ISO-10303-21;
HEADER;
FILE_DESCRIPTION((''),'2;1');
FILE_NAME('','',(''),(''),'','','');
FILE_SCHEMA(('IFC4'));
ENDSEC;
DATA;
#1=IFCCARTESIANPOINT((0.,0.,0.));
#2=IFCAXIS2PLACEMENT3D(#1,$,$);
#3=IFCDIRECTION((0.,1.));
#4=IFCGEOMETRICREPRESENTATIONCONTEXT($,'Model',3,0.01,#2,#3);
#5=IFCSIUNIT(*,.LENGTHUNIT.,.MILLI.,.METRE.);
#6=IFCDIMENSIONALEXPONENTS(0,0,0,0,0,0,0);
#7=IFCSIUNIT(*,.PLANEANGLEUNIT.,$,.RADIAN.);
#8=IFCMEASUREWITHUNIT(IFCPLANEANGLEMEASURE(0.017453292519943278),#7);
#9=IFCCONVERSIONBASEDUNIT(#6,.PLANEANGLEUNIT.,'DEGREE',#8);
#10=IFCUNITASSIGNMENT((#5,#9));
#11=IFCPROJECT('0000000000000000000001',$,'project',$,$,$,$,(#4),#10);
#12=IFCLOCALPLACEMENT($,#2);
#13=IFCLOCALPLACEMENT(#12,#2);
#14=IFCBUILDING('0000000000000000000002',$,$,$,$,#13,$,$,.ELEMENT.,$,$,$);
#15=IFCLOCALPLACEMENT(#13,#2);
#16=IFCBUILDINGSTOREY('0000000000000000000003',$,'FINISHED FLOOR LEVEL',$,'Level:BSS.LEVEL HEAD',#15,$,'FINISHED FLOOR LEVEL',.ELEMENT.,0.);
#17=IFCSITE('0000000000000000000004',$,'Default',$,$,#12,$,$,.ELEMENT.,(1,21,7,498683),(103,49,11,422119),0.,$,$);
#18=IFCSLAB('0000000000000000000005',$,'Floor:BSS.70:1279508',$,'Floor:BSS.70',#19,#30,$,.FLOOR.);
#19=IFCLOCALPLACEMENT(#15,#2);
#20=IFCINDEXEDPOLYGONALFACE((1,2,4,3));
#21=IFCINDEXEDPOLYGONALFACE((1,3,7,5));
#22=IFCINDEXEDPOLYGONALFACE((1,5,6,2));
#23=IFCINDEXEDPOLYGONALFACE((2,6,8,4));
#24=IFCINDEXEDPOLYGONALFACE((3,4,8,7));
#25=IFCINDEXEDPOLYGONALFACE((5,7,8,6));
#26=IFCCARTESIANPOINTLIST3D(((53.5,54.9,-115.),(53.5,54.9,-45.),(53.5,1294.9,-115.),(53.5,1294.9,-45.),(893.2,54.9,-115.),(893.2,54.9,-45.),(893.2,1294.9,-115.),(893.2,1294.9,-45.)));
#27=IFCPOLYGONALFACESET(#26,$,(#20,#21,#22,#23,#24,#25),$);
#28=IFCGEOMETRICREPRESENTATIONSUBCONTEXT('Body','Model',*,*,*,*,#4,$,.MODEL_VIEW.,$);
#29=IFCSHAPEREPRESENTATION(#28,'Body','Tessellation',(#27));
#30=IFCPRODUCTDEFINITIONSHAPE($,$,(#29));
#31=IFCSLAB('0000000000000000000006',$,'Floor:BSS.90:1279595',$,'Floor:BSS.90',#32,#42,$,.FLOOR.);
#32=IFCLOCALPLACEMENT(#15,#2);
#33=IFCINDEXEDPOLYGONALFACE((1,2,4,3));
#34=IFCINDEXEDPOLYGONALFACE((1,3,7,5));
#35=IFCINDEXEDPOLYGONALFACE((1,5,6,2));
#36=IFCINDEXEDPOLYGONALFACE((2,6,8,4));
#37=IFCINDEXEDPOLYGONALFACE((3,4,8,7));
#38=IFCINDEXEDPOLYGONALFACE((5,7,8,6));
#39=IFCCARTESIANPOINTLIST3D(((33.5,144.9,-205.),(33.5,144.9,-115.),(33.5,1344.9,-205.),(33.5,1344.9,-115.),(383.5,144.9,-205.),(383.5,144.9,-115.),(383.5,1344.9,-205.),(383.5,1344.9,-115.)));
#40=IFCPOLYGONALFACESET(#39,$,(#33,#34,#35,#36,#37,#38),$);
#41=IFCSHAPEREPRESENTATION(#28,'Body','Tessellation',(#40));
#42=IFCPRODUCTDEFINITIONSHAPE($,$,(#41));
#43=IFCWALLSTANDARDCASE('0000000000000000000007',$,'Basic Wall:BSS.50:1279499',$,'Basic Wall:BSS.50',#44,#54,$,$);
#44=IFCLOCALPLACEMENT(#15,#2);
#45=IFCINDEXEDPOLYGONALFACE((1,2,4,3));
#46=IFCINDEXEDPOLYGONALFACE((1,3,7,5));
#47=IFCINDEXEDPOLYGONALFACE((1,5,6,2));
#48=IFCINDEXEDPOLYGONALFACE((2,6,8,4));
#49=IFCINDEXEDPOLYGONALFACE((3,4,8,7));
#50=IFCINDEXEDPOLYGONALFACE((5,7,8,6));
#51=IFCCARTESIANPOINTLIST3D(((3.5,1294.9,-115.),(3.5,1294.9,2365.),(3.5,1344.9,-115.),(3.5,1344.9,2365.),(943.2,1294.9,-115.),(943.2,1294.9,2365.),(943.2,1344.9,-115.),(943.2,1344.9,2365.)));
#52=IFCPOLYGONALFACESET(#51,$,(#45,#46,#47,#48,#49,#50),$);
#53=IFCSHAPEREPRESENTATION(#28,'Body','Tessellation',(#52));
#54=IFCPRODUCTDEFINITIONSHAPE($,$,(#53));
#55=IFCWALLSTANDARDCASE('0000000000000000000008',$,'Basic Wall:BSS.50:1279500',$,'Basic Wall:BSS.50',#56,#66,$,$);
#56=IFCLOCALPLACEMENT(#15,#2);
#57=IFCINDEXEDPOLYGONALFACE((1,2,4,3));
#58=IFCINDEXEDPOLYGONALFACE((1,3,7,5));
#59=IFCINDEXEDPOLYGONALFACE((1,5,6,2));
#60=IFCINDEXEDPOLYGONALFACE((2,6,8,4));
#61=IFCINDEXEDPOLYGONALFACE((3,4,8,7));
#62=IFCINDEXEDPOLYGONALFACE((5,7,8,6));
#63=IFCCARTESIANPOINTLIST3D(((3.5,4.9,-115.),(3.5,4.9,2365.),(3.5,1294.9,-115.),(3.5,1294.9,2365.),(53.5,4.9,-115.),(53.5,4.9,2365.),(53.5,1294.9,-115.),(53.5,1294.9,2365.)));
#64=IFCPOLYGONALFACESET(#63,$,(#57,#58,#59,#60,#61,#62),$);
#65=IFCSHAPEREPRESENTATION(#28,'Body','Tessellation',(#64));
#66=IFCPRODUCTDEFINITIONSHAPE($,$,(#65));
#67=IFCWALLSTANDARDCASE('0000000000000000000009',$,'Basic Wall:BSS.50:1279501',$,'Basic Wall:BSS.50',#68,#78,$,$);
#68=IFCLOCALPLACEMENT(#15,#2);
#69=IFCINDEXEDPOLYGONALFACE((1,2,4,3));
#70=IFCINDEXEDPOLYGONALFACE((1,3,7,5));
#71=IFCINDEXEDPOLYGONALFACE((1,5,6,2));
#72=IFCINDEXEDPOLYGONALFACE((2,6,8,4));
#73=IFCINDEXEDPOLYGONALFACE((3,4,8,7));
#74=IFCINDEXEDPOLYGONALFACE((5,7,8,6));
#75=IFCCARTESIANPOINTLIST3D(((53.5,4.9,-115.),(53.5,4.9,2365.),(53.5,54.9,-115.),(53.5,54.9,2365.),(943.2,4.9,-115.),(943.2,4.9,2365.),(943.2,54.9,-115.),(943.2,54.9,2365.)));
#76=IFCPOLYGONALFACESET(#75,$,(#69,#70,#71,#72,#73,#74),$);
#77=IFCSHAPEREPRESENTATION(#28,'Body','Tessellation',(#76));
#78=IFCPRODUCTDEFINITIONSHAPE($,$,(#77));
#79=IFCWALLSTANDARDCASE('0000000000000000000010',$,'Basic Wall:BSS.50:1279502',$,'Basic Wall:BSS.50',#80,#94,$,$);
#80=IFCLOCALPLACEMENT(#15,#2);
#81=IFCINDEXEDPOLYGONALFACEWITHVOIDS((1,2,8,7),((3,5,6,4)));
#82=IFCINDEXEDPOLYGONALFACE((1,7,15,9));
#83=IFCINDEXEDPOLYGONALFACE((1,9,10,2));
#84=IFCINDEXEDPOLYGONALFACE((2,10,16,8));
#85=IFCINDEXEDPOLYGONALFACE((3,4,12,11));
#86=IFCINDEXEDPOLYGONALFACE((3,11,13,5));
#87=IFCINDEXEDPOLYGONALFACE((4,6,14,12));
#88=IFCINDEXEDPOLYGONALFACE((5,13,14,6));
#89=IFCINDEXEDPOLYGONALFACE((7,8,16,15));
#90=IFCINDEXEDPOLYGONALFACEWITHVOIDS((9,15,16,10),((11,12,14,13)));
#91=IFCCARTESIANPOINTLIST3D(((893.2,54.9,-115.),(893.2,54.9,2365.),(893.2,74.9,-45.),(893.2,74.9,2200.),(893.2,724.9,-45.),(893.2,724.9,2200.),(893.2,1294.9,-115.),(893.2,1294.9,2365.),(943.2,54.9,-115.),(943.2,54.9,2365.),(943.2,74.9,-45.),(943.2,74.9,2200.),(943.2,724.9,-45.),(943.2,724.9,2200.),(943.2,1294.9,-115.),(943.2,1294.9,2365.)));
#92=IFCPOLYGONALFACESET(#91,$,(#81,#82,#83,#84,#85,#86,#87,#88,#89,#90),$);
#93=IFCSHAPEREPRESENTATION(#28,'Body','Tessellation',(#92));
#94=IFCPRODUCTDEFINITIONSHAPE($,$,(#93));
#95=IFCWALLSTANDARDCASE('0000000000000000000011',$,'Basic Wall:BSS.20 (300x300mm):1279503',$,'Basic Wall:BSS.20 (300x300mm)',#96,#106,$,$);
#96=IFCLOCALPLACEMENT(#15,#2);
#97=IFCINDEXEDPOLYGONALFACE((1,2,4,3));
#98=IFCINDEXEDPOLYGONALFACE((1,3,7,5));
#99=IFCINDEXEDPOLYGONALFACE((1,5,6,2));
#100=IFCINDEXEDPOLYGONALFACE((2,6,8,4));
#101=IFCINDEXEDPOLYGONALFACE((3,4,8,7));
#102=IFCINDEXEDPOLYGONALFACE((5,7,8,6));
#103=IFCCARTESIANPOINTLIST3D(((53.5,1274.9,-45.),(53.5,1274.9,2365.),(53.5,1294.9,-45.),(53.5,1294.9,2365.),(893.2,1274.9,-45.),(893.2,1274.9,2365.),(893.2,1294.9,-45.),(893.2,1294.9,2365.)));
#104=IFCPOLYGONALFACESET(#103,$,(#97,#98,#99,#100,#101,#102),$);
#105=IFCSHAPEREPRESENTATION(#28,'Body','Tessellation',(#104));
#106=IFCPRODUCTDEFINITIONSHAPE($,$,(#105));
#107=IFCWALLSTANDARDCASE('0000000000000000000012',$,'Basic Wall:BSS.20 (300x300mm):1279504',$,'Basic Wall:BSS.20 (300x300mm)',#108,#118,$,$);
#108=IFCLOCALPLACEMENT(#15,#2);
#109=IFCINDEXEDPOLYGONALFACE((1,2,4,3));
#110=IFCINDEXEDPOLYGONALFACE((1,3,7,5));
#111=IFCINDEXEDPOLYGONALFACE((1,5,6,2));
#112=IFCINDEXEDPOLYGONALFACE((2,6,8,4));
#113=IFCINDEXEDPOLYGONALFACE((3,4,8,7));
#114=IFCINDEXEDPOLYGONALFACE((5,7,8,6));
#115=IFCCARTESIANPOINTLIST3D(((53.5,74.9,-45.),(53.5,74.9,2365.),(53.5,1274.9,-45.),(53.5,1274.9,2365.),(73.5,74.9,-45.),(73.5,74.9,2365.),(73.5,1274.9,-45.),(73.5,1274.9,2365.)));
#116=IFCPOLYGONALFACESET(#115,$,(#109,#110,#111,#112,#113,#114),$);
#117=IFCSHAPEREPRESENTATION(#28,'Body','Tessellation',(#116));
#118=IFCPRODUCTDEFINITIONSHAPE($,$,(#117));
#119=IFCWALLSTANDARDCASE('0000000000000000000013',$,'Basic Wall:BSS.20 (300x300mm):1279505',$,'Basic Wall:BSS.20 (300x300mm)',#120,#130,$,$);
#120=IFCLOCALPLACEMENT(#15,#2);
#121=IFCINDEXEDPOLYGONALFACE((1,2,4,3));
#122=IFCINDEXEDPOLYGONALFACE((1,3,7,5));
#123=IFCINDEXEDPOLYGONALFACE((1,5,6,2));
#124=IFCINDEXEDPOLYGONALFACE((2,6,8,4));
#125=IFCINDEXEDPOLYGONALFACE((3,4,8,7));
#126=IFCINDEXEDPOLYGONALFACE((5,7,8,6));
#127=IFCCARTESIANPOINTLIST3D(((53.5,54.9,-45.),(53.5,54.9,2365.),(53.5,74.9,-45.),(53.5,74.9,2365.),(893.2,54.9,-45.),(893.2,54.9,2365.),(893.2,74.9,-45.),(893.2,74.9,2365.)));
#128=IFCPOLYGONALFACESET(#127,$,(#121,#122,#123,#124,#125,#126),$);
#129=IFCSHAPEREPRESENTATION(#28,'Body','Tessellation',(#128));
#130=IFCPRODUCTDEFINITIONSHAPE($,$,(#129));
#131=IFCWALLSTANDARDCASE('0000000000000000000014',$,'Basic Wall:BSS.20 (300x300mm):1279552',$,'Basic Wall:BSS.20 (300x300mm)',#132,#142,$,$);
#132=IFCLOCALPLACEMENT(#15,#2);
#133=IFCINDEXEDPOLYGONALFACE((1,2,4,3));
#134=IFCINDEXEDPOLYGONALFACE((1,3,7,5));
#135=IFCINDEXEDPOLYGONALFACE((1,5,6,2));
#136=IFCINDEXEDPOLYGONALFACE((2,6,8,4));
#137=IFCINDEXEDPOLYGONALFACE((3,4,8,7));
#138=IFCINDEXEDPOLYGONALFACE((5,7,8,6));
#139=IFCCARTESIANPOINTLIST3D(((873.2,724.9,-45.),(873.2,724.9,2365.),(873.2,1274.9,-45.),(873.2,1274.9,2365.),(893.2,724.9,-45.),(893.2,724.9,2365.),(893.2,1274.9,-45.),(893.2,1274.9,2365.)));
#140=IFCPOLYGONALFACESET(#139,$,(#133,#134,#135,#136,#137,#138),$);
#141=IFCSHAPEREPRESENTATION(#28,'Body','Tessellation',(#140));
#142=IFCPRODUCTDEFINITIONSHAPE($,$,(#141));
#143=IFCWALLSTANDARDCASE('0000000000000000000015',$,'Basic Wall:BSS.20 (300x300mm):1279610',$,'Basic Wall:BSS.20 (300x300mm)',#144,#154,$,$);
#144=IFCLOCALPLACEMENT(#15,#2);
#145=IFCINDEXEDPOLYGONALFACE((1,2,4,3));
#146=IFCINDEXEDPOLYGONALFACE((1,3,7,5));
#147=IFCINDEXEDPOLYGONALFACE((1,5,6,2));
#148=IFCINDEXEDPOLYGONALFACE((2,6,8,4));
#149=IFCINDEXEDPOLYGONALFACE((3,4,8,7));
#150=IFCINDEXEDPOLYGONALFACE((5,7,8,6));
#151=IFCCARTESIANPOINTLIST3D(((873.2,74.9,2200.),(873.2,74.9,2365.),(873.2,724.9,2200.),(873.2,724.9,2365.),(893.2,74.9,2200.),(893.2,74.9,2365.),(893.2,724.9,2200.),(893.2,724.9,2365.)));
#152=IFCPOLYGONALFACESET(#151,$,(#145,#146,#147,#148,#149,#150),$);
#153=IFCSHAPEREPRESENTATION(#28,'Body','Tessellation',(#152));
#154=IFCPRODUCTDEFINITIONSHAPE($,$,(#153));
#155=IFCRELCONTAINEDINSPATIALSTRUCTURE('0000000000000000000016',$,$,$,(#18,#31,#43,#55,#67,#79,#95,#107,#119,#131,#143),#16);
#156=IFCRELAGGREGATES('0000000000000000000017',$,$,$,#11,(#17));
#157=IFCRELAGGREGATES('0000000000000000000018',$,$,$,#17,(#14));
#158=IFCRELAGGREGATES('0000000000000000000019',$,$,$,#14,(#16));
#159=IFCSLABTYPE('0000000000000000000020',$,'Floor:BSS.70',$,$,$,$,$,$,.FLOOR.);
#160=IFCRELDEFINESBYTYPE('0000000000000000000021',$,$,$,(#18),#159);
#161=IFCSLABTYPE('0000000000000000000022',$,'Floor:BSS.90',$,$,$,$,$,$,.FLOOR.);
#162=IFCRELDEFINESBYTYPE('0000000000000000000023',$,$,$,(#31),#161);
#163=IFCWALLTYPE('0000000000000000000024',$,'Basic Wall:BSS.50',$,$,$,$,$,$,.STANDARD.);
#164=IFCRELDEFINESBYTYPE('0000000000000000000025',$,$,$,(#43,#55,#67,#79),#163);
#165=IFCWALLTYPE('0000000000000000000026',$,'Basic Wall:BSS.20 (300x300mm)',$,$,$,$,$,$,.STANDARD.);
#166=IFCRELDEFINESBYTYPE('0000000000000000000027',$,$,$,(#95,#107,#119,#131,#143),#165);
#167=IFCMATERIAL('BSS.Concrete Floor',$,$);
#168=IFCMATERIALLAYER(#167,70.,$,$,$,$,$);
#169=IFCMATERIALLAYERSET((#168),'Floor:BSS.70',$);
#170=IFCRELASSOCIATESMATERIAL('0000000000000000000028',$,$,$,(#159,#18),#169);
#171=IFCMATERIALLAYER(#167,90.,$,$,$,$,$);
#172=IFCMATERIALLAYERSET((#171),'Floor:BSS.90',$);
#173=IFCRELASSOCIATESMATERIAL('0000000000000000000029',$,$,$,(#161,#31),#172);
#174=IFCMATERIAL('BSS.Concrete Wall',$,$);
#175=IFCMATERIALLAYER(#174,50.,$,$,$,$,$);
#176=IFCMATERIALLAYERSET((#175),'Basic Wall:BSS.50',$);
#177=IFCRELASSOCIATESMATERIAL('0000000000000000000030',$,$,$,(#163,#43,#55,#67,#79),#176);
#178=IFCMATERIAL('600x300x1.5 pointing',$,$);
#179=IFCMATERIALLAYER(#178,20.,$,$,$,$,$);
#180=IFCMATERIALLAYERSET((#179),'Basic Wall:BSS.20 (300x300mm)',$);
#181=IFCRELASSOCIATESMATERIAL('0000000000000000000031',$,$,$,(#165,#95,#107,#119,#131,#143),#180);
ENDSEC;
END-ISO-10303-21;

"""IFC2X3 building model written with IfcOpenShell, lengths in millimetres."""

from ifc_helpers import new_model, entity, si_unit, converted_unit, direction, frame, frame_2d, origin, place, context, subcontext, project, spatial, polyline, rectangle, extrude, clip, halfspace, bounded_halfspace, material, layer, layer_set, layer_usage, type_object, element, save


model = new_model("IFC2X3")

# Units and contexts
model_context = context("Model", 3, precision=0.01, world=origin(), true_north=direction((0.0, 1.0)))
body_context = subcontext(model_context, "Body", "Model", "MODEL_VIEW")
ifc_project = project(units=[si_unit("LENGTHUNIT", "METRE", prefix="MILLI"), converted_unit("PLANEANGLEUNIT", "DEGREE", entity("IfcPlaneAngleMeasure", 0.017453292519943278), si_unit("PLANEANGLEUNIT", "RADIAN"), dimensions=[0, 0, 0, 0, 0, 0, 0])], contexts=[model_context])

# Site, building, storey
site_placement = place(None, origin())
site = spatial("IfcSite", under=ifc_project, at=site_placement, Name="Default", CompositionType="ELEMENT", RefLatitude=(1, 21, 7, 498683), RefLongitude=(103, 49, 11, 422119), RefElevation=0.0)
building_placement = place(site_placement, origin())
building = spatial("IfcBuilding", under=site, at=building_placement, CompositionType="ELEMENT")
storey_placement = place(building_placement, origin())
storey = spatial("IfcBuildingStorey", under=building, at=storey_placement, Name="FINISHED FLOOR LEVEL", ObjectType="Level:BSS.LEVEL HEAD", LongName="FINISHED FLOOR LEVEL", CompositionType="ELEMENT", Elevation=0.0)

# Slabs
ifc_material_1 = material(Name="BSS.Concrete Floor")
ifc_layer_1 = layer(ifc_material_1, 70.0)
ifc_layer_set_1 = layer_set([ifc_layer_1], Name="Floor:BSS.70")
ifc_layer_usage_1 = layer_usage(ifc_layer_set_1, "AXIS3", "POSITIVE", 0.0)
slab_type_1 = type_object("IfcSlabType", Name="Floor:BSS.70", PredefinedType="FLOOR", material=ifc_layer_set_1)
slab_1_placement = place(storey_placement, origin())
element("IfcSlab", 1, at=slab_1_placement, inside=storey, type_object=slab_type_1, material=ifc_layer_usage_1, Name="Floor:BSS.70:1279508", ObjectType="Floor:BSS.70", PredefinedType="FLOOR", context=body_context, shape_type="SweptSolid", body=[
    extrude(rectangle(XDim=1240.0, YDim=839.7, at=frame_2d((0.0, 0.0), x_axis=(1.0, 0.0))), frame((473.3, 674.9, -45.0), z_axis=(0.0, 0.0, -1.0), x_axis=(0.0, 1.0, 0.0)), (0.0, 0.0, 1.0), 70.0),
])
ifc_material_2 = material(Name="600x300x1.5 pointing")
ifc_layer_2 = layer(ifc_material_1, 90.0)
ifc_layer_set_2 = layer_set([ifc_layer_2], Name="Floor:BSS.90")
ifc_layer_usage_2 = layer_usage(ifc_layer_set_2, "AXIS3", "POSITIVE", 0.0)
slab_type_2 = type_object("IfcSlabType", Name="Floor:BSS.90", PredefinedType="FLOOR", material=ifc_layer_set_2)
slab_2_placement = place(storey_placement, origin())
element("IfcSlab", 2, at=slab_2_placement, inside=storey, type_object=slab_type_2, material=ifc_layer_usage_2, Name="Floor:BSS.90:1279595", ObjectType="Floor:BSS.90", PredefinedType="FLOOR", context=body_context, shape_type="SweptSolid", body=[
    extrude(rectangle(XDim=1200.0, YDim=350.0, at=frame_2d((0.0, 0.0), x_axis=(1.0, 0.0))), frame((208.5, 744.9, -115.0), z_axis=(0.0, 0.0, -1.0), x_axis=(0.0, 1.0, 0.0)), (0.0, 0.0, 1.0), 90.0),
])

# Walls
ifc_material_3 = material(Name="BSS.Concrete Wall")
ifc_layer_3 = layer(ifc_material_3, 50.0)
ifc_layer_set_3 = layer_set([ifc_layer_3], Name="Basic Wall:BSS.50")
ifc_layer_usage_3 = layer_usage(ifc_layer_set_3, "AXIS2", "POSITIVE", -25.0)
wall_type_1 = type_object("IfcWallType", Name="Basic Wall:BSS.50", PredefinedType="STANDARD", material=ifc_layer_set_3)
wall_1_placement = place(storey_placement, frame((943.2, 1319.9, -115.0), z_axis=(0.0, 0.0, 1.0), x_axis=(-1.0, 0.0, 0.0)))
element("IfcWallStandardCase", 3, at=wall_1_placement, inside=storey, type_object=wall_type_1, material=ifc_layer_usage_3, Name="Basic Wall:BSS.50:1279499", ObjectType="Basic Wall:BSS.50", context=body_context, shape_type="Clipping", body=[
    clip(extrude(rectangle(XDim=939.7, YDim=50.0, at=frame_2d((469.9, 0.0), x_axis=(-1.0, 0.0))), origin(), (0.0, 0.0, 1.0), 2480.0), bounded_halfspace(frame((0.0, -25.0, 2480.0), z_axis=(0.0, 0.0, -1.0), x_axis=(0.0, 1.0, 0.0)), True, frame((0.0, -25.0, 2480.0)), polyline([(0.0, 0.0), (939.7, 0.0), (939.7, 50.0), (889.7, 50.0), (50.0, 50.0), (0.0, 50.0), (0.0, 0.0)]))),
])
ifc_layer_usage_4 = layer_usage(ifc_layer_set_3, "AXIS2", "NEGATIVE", 25.0)
wall_2_placement = place(storey_placement, frame((28.5, 1294.9, -115.0), z_axis=(0.0, 0.0, 1.0), x_axis=(0.0, -1.0, 0.0)))
element("IfcWallStandardCase", 4, at=wall_2_placement, inside=storey, type_object=wall_type_1, material=ifc_layer_usage_4, Name="Basic Wall:BSS.50:1279500", ObjectType="Basic Wall:BSS.50", context=body_context, shape_type="Clipping", body=[
    clip(extrude(rectangle(XDim=1290.0, YDim=50.0, at=frame_2d((645.0, 0.0), x_axis=(-1.0, 0.0))), origin(), (0.0, 0.0, 1.0), 2480.0), bounded_halfspace(frame((0.0, -25.0, 2480.0), z_axis=(0.0, 0.0, -1.0), x_axis=(1.0, 0.0, 0.0)), True, frame((0.0, -25.0, 2480.0)), polyline([(0.0, 0.0), (1290.0, 0.0), (1290.0, 50.0), (1240.0, 50.0), (0.0, 50.0), (0.0, 0.0)]))),
])
ifc_layer_usage_5 = layer_usage(ifc_layer_set_3, "AXIS2", "NEGATIVE", 25.0)
wall_3_placement = place(storey_placement, frame((53.5, 29.9, -115.0)))
element("IfcWallStandardCase", 5, at=wall_3_placement, inside=storey, type_object=wall_type_1, material=ifc_layer_usage_5, Name="Basic Wall:BSS.50:1279501", ObjectType="Basic Wall:BSS.50", context=body_context, shape_type="Clipping", body=[
    clip(extrude(rectangle(XDim=889.7, YDim=50.0, at=frame_2d((444.9, 0.0), x_axis=(-1.0, 0.0))), origin(), (0.0, 0.0, 1.0), 2480.0), bounded_halfspace(frame((0.0, -25.0, 2480.0), z_axis=(0.0, 0.0, -1.0), x_axis=(0.0, -1.0, 0.0)), True, frame((0.0, -25.0, 2480.0)), polyline([(0.0, 0.0), (889.7, 0.0), (889.7, 50.0), (839.7, 50.0), (0.0, 50.0), (0.0, 0.0)]))),
])

# Wall, opening
ifc_layer_usage_6 = layer_usage(ifc_layer_set_3, "AXIS2", "POSITIVE", -25.0)
wall_4_placement = place(storey_placement, frame((918.2, 54.9, -115.0), z_axis=(0.0, 0.0, 1.0), x_axis=(0.0, 1.0, 0.0)))
wall_4 = element("IfcWallStandardCase", 6, at=wall_4_placement, inside=storey, type_object=wall_type_1, material=ifc_layer_usage_6, Name="Basic Wall:BSS.50:1279502", ObjectType="Basic Wall:BSS.50", context=body_context, shape_type="Clipping", body=[
    clip(extrude(rectangle(XDim=1240.0, YDim=50.0, at=frame_2d((620.0, 0.0), x_axis=(-1.0, 0.0))), origin(), (0.0, 0.0, 1.0), 2480.0), bounded_halfspace(frame((0.0, -25.0, 2480.0), z_axis=(0.0, 0.0, -1.0), x_axis=(-1.0, 0.0, 0.0)), True, frame((0.0, -25.0, 2480.0)), polyline([(0.0, 0.0), (1240.0, 0.0), (1240.0, 50.0), (1220.0, 50.0), (0.0, 50.0), (0.0, 0.0)]))),
])
opening_placement = place(wall_4_placement, frame((-54.9, 918.2, 115.0), z_axis=(0.0, 0.0, 1.0), x_axis=(0.0, -1.0, 0.0)))
element("IfcOpeningElement", 7, at=opening_placement, cuts=wall_4, ObjectType="Opening", context=body_context, shape_type="SweptSolid", body=[
    extrude(rectangle(XDim=2245.0, YDim=650.0, at=frame_2d((0.0, 0.0), x_axis=(0.0, 1.0))), frame((2417.2, 399.9, 1077.5), z_axis=(-1.0, 0.0, 0.0), x_axis=(0.0, 1.0, 0.0)), (0.0, 0.0, 1.0), 3048.0),
])

# Walls
ifc_layer_4 = layer(ifc_material_2, 20.0)
ifc_layer_set_4 = layer_set([ifc_layer_4], Name="Basic Wall:BSS.20 (300x300mm)")
ifc_layer_usage_7 = layer_usage(ifc_layer_set_4, "AXIS2", "POSITIVE", -10.0)
wall_type_2 = type_object("IfcWallType", Name="Basic Wall:BSS.20 (300x300mm)", PredefinedType="STANDARD", material=ifc_layer_set_4)
wall_5_placement = place(storey_placement, frame((893.2, 1284.9, -45.0), z_axis=(0.0, 0.0, 1.0), x_axis=(-1.0, 0.0, 0.0)))
element("IfcWallStandardCase", 8, at=wall_5_placement, inside=storey, type_object=wall_type_2, material=ifc_layer_usage_7, Name="Basic Wall:BSS.20 (300x300mm):1279503", ObjectType="Basic Wall:BSS.20 (300x300mm)", context=body_context, shape_type="SweptSolid", body=[
    extrude(rectangle(XDim=839.7, YDim=20.0, at=frame_2d((419.9, 0.0), x_axis=(-1.0, 0.0))), origin(), (0.0, 0.0, 1.0), 2410.0),
])
ifc_layer_usage_8 = layer_usage(ifc_layer_set_4, "AXIS2", "NEGATIVE", 10.0)
wall_6_placement = place(storey_placement, frame((63.5, 74.9, -45.0), z_axis=(0.0, 0.0, 1.0), x_axis=(0.0, 1.0, 0.0)))
element("IfcWallStandardCase", 9, at=wall_6_placement, inside=storey, type_object=wall_type_2, material=ifc_layer_usage_8, Name="Basic Wall:BSS.20 (300x300mm):1279504", ObjectType="Basic Wall:BSS.20 (300x300mm)", context=body_context, shape_type="SweptSolid", body=[
    extrude(rectangle(XDim=1200.0, YDim=20.0, at=frame_2d((600.0, 0.0), x_axis=(-1.0, 0.0))), origin(), (0.0, 0.0, 1.0), 2410.0),
])
ifc_layer_usage_9 = layer_usage(ifc_layer_set_4, "AXIS2", "POSITIVE", -10.0)
wall_7_placement = place(storey_placement, frame((53.5, 64.9, -45.0)))
element("IfcWallStandardCase", 10, at=wall_7_placement, inside=storey, type_object=wall_type_2, material=ifc_layer_usage_9, Name="Basic Wall:BSS.20 (300x300mm):1279505", ObjectType="Basic Wall:BSS.20 (300x300mm)", context=body_context, shape_type="SweptSolid", body=[
    extrude(rectangle(XDim=839.7, YDim=20.0, at=frame_2d((419.9, 0.0), x_axis=(-1.0, 0.0))), origin(), (0.0, 0.0, 1.0), 2410.0),
])
ifc_layer_usage_10 = layer_usage(ifc_layer_set_4, "AXIS2", "POSITIVE", -10.0)
wall_8_placement = place(storey_placement, frame((883.2, 724.9, -45.0), z_axis=(0.0, 0.0, 1.0), x_axis=(0.0, 1.0, 0.0)))
element("IfcWallStandardCase", 11, at=wall_8_placement, inside=storey, type_object=wall_type_2, material=ifc_layer_usage_10, Name="Basic Wall:BSS.20 (300x300mm):1279552", ObjectType="Basic Wall:BSS.20 (300x300mm)", context=body_context, shape_type="SweptSolid", body=[
    extrude(rectangle(XDim=550.0, YDim=20.0, at=frame_2d((275.0, 0.0), x_axis=(-1.0, 0.0))), origin(), (0.0, 0.0, 1.0), 2410.0),
])
ifc_layer_usage_11 = layer_usage(ifc_layer_set_4, "AXIS2", "POSITIVE", -10.0)
wall_9_placement = place(storey_placement, frame((883.2, 74.9, 2200.0), z_axis=(0.0, 0.0, 1.0), x_axis=(0.0, 1.0, 0.0)))
element("IfcWallStandardCase", 12, at=wall_9_placement, inside=storey, type_object=wall_type_2, material=ifc_layer_usage_11, Name="Basic Wall:BSS.20 (300x300mm):1279610", ObjectType="Basic Wall:BSS.20 (300x300mm)", context=body_context, shape_type="Clipping", body=[
    clip(extrude(rectangle(XDim=650.0, YDim=20.0, at=frame_2d((325.0, 0.0), x_axis=(-1.0, 0.0))), origin(), (0.0, 0.0, 1.0), 165.0), halfspace(frame((650.0, -10.0, 0.0), z_axis=(0.0, 0.0, -1.0), x_axis=(0.0, 1.0, 0.0)), False)),
])

save(model, "model.ifc")
